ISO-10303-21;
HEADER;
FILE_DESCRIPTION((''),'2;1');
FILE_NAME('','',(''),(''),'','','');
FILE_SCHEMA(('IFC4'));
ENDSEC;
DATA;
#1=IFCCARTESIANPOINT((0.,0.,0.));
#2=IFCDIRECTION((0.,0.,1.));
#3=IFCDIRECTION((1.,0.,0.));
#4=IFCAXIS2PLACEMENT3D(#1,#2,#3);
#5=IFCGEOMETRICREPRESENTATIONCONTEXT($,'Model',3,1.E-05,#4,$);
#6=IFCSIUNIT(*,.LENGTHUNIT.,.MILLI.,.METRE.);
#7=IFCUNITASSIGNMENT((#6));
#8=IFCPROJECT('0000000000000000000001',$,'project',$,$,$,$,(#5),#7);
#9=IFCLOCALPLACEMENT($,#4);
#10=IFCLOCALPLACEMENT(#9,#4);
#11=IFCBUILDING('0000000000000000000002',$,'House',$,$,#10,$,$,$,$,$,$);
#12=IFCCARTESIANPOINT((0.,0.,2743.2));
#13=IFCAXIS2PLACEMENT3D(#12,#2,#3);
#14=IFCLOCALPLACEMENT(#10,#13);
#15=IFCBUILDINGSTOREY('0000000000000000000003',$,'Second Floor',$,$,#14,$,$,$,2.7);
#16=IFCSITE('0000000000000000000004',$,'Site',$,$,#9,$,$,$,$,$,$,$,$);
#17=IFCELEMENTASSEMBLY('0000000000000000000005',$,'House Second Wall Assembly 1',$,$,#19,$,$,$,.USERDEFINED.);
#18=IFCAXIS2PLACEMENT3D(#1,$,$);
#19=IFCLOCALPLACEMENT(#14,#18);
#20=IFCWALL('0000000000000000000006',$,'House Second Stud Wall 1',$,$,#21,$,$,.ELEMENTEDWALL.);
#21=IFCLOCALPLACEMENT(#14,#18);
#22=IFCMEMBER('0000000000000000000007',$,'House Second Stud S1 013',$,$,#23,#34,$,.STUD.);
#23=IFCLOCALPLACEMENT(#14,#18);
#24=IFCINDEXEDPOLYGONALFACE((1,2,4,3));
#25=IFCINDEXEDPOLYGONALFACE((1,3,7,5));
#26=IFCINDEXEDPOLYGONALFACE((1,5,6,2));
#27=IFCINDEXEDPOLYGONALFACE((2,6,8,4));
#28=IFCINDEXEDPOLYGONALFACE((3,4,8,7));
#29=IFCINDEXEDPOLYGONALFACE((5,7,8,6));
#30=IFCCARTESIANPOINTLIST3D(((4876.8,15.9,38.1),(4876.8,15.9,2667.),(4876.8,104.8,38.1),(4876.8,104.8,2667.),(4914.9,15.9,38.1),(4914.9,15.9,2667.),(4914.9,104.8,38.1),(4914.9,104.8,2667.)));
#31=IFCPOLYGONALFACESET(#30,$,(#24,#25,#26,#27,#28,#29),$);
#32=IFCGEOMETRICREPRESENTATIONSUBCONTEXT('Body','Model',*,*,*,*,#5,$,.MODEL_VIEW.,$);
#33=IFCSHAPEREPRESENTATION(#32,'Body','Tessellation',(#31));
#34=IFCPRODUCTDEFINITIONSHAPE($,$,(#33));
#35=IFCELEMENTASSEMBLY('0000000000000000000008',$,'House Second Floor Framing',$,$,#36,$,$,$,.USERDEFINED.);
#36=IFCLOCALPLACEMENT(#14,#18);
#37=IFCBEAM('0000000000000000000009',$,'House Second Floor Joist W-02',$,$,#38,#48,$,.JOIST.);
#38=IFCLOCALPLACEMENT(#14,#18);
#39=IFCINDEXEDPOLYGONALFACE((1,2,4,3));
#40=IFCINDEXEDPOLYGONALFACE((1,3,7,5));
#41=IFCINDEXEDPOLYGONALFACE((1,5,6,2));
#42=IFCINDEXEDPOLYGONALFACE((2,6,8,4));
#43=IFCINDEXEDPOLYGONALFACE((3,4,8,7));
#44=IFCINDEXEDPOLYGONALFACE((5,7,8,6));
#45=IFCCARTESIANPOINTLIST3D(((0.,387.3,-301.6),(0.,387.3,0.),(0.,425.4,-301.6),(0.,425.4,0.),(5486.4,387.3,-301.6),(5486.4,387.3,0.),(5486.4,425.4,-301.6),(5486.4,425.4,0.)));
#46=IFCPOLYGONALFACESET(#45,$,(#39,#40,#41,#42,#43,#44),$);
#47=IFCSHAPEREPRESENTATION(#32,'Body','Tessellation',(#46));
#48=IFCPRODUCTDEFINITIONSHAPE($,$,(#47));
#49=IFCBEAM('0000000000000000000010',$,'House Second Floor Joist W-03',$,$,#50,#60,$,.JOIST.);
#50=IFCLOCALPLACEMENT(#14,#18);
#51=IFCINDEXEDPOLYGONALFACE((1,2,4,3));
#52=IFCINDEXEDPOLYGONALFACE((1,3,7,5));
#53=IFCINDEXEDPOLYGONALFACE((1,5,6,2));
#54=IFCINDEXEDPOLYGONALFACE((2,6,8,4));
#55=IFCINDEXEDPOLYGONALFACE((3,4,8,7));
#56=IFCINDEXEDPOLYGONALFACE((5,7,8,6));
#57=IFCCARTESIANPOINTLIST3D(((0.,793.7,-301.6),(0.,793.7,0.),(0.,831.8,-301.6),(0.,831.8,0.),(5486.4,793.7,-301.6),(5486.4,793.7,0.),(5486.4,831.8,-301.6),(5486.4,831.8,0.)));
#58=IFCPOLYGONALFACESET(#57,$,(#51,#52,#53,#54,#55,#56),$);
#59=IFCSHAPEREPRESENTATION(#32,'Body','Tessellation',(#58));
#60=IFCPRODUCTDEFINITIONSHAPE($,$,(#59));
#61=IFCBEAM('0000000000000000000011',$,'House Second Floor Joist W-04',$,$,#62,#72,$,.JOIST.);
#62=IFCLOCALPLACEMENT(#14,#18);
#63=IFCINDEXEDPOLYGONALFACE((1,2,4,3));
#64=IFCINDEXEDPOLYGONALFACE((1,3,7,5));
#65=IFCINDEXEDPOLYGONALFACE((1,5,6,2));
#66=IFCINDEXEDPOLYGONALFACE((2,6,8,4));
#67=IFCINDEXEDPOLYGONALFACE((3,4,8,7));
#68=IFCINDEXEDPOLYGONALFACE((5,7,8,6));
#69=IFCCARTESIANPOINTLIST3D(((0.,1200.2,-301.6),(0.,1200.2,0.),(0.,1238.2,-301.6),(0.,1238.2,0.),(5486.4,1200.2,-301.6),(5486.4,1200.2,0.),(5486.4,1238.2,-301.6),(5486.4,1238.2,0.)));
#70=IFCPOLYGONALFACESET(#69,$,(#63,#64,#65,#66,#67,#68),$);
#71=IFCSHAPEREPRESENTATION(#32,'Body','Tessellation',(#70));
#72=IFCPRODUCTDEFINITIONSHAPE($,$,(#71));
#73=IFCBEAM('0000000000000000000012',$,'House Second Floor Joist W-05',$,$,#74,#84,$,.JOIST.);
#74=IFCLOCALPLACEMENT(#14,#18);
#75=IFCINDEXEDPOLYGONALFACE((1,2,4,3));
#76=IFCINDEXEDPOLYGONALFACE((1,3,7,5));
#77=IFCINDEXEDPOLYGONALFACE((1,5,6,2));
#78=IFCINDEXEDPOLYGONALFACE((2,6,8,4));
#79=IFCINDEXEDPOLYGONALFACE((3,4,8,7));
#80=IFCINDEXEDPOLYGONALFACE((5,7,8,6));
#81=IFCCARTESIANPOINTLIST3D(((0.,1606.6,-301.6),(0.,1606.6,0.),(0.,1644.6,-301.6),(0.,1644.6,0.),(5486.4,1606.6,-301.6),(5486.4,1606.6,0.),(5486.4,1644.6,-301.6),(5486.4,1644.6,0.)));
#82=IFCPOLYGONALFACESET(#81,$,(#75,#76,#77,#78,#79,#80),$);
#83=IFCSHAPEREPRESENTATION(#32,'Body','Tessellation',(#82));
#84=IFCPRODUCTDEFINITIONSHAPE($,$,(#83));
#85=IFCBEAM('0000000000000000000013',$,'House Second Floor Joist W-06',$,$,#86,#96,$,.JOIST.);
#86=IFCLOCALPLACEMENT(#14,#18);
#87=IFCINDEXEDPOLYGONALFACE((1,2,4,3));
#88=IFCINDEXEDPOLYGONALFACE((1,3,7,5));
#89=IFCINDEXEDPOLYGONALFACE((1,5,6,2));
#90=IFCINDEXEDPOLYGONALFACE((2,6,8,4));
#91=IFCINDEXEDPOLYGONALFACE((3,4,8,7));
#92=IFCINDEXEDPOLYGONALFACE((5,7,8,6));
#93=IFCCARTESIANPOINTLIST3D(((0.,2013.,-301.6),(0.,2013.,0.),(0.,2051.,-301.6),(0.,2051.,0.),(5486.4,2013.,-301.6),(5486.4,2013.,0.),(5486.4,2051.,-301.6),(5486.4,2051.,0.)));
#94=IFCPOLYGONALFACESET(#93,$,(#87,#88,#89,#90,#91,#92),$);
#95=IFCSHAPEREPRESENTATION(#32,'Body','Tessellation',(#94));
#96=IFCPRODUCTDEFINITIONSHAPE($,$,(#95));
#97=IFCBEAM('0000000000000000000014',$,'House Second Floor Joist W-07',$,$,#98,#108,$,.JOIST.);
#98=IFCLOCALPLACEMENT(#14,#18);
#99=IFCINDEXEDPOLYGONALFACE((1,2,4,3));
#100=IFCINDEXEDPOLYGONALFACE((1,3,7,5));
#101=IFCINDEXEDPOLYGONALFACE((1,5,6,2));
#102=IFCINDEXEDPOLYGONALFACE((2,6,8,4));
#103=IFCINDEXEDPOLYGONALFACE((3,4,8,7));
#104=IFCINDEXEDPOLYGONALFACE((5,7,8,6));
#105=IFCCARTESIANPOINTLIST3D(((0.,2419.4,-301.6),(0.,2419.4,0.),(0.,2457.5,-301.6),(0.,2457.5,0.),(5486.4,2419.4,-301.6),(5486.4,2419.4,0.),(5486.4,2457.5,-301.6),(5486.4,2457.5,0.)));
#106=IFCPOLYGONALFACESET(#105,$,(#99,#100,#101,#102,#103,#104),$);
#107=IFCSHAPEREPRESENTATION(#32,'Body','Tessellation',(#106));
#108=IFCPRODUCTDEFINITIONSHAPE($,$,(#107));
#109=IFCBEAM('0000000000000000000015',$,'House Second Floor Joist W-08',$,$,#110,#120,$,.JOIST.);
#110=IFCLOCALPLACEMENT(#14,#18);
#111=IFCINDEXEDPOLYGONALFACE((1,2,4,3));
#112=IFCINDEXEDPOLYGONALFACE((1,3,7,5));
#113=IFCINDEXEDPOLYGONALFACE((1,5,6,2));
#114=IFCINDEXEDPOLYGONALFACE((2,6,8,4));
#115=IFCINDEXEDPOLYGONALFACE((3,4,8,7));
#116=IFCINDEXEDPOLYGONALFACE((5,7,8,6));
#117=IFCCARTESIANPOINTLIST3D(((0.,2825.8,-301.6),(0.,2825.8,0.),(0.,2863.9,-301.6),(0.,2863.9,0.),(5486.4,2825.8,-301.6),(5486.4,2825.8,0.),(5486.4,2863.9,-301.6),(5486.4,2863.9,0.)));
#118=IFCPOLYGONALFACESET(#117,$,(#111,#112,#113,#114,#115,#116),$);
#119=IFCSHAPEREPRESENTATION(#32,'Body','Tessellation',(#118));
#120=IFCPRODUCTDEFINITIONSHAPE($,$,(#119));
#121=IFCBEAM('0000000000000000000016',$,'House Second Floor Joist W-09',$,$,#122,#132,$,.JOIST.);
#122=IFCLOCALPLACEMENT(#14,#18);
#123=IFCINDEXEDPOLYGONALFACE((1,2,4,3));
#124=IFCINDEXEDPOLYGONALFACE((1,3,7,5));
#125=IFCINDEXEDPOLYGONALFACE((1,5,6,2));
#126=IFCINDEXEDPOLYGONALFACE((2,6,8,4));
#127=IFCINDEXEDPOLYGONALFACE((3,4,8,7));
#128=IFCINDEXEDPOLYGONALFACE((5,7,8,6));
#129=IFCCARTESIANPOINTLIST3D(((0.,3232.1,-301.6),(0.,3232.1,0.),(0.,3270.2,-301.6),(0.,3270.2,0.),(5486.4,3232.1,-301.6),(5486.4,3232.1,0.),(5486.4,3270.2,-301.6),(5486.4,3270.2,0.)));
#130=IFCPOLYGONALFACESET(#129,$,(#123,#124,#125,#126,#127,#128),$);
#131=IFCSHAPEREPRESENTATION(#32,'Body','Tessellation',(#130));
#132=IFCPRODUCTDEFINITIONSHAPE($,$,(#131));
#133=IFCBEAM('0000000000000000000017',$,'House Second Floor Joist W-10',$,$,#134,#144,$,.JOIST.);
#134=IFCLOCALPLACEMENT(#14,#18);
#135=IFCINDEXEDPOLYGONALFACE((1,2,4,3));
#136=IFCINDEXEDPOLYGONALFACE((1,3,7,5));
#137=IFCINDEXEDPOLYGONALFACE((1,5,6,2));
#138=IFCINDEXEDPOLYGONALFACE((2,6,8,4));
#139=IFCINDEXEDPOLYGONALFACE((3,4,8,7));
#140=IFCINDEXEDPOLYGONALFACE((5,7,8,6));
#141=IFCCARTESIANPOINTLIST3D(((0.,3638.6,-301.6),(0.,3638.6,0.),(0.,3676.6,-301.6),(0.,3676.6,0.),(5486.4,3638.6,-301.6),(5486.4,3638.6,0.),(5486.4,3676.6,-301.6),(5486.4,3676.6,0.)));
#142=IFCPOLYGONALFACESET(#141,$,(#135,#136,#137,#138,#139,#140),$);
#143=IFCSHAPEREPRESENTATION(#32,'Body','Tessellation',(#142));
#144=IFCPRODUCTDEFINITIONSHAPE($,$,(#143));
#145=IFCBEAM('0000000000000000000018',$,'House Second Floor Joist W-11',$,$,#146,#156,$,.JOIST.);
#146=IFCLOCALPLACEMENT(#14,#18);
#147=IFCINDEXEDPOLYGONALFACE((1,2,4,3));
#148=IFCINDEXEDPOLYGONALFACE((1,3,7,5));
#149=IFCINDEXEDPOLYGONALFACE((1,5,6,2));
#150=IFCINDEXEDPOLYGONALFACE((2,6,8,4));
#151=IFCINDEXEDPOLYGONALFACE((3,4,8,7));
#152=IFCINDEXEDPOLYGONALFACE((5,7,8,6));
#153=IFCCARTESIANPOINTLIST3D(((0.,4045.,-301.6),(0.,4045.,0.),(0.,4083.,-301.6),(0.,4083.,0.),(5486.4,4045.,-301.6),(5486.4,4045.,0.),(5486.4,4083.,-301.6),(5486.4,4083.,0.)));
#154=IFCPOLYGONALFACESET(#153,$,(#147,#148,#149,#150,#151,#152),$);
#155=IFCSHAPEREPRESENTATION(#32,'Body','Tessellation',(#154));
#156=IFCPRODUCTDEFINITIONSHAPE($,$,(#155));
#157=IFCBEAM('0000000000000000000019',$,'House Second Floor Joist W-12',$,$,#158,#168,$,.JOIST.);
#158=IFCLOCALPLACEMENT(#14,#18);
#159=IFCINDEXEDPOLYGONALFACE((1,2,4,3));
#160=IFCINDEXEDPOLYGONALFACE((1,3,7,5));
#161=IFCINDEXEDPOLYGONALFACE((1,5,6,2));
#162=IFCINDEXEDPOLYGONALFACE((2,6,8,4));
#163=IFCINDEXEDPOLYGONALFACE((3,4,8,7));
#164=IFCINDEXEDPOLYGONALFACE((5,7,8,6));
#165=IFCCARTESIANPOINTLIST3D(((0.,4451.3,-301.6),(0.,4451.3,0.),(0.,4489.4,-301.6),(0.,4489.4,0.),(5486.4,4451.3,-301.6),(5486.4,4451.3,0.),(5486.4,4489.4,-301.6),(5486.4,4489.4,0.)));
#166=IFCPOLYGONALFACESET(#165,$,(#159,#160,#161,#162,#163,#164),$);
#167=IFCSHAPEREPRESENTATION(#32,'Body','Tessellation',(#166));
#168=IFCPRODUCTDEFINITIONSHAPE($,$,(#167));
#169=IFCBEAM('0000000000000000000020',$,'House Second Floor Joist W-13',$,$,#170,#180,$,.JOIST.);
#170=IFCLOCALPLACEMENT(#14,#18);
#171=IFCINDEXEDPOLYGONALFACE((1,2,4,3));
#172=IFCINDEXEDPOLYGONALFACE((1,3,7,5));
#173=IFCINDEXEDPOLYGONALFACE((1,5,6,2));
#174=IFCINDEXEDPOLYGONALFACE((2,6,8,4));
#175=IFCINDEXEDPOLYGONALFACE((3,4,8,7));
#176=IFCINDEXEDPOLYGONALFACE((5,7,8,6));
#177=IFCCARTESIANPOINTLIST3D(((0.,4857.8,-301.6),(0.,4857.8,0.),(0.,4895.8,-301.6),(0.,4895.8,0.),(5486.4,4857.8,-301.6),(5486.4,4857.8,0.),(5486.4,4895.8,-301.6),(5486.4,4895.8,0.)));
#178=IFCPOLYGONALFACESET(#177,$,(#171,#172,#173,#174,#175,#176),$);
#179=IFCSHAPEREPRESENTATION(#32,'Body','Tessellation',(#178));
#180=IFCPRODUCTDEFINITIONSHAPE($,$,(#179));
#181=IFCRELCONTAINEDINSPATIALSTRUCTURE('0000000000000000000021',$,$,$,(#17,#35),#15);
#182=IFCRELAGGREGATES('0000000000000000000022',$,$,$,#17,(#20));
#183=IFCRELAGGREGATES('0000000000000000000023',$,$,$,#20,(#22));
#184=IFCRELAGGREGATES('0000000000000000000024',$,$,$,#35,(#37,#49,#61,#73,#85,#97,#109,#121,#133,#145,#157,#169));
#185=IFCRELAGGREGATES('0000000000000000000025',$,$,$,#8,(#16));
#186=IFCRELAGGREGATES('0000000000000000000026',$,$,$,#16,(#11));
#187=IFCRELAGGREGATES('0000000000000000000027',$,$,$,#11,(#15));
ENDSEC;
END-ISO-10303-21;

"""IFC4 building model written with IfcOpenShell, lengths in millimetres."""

from ifc_helpers import new_model, si_unit, frame, origin_with_axes, origin_2d, place, context, subcontext, project, spatial, rectangle, extrude, element, aggregate, save


model = new_model("IFC4")

# Units and contexts
model_context = context("Model", 3, precision=1e-05, world=origin_with_axes())
body_context = subcontext(model_context, "Body", "Model", "MODEL_VIEW")
ifc_project = project(units=[si_unit("LENGTHUNIT", "METRE", prefix="MILLI")], contexts=[model_context])

# Site, building, storey
site_placement = place(None, origin_with_axes())
site = spatial("IfcSite", under=ifc_project, at=site_placement, Name="Site")
building_placement = place(site_placement, origin_with_axes())
building = spatial("IfcBuilding", under=site, at=building_placement, Name="House")
storey_placement = place(building_placement, frame((0.0, 0.0, 2743.2), z_axis=(0.0, 0.0, 1.0), x_axis=(1.0, 0.0, 0.0)))
storey = spatial("IfcBuildingStorey", under=building, at=storey_placement, Name="Second Floor", Elevation=2.7)

# Element assembly, wall, member
assembly_1_placement = place(storey_placement, frame((0.0, 0.0, -2743.2), z_axis=(0.0, 0.0, 1.0), x_axis=(1.0, 0.0, 0.0)))
assembly_1 = element("IfcElementAssembly", 1, at=assembly_1_placement, inside=storey, Name="House Second Wall Assembly 1", PredefinedType="USERDEFINED")
wall_1_placement = place(assembly_1_placement, frame((0.0, 0.0, 2743.2), z_axis=(0.0, 0.0, 1.0), x_axis=(1.0, 0.0, 0.0)))
wall_1 = element("IfcWall", 2, at=wall_1_placement, Name="House Second Stud Wall 1", PredefinedType="ELEMENTEDWALL")
aggregate(assembly_1, [wall_1])
member_1_placement = place(wall_1_placement, frame((4895.9, 60.3, 38.1), z_axis=(0.0, 0.0, 1.0), x_axis=(1.0, 0.0, 0.0)))
member_1 = element("IfcMember", 3, at=member_1_placement, Name="House Second Stud S1 013", PredefinedType="STUD", context=body_context, shape_type="SweptSolid", body=[
    extrude(rectangle(XDim=38.1, YDim=88.9, at=origin_2d()), origin_with_axes(), (0.0, 0.0, 1.0), 2628.9),
])
aggregate(wall_1, [member_1])

# Element assembly, beams
assembly_2_placement = place(storey_placement, frame((0.0, 0.0, -2743.2), z_axis=(0.0, 0.0, 1.0), x_axis=(1.0, 0.0, 0.0)))
assembly_2 = element("IfcElementAssembly", 4, at=assembly_2_placement, inside=storey, Name="House Second Floor Framing", PredefinedType="USERDEFINED")
beam_1_placement = place(assembly_2_placement, frame((0.0, 406.4, 2592.4), z_axis=(1.0, 0.0, 0.0), x_axis=(0.0, 1.0, 0.0)))
beam_1 = element("IfcBeam", 5, at=beam_1_placement, Name="House Second Floor Joist W-02", PredefinedType="JOIST", context=body_context, shape_type="SweptSolid", body=[
    extrude(rectangle(XDim=38.1, YDim=301.6, at=origin_2d()), origin_with_axes(), (0.0, 0.0, 1.0), 5486.4),
])
beam_2_placement = place(assembly_2_placement, frame((0.0, 812.8, 2592.4), z_axis=(1.0, 0.0, 0.0), x_axis=(0.0, 1.0, 0.0)))
beam_2 = element("IfcBeam", 6, at=beam_2_placement, Name="House Second Floor Joist W-03", PredefinedType="JOIST", context=body_context, shape_type="SweptSolid", body=[
    extrude(rectangle(XDim=38.1, YDim=301.6, at=origin_2d()), origin_with_axes(), (0.0, 0.0, 1.0), 5486.4),
])
beam_3_placement = place(assembly_2_placement, frame((0.0, 1219.2, 2592.4), z_axis=(1.0, 0.0, 0.0), x_axis=(0.0, 1.0, 0.0)))
beam_3 = element("IfcBeam", 7, at=beam_3_placement, Name="House Second Floor Joist W-04", PredefinedType="JOIST", context=body_context, shape_type="SweptSolid", body=[
    extrude(rectangle(XDim=38.1, YDim=301.6, at=origin_2d()), origin_with_axes(), (0.0, 0.0, 1.0), 5486.4),
])
beam_4_placement = place(assembly_2_placement, frame((0.0, 1625.6, 2592.4), z_axis=(1.0, 0.0, 0.0), x_axis=(0.0, 1.0, 0.0)))
beam_4 = element("IfcBeam", 8, at=beam_4_placement, Name="House Second Floor Joist W-05", PredefinedType="JOIST", context=body_context, shape_type="SweptSolid", body=[
    extrude(rectangle(XDim=38.1, YDim=301.6, at=origin_2d()), origin_with_axes(), (0.0, 0.0, 1.0), 5486.4),
])
beam_5_placement = place(assembly_2_placement, frame((0.0, 2032.0, 2592.4), z_axis=(1.0, 0.0, 0.0), x_axis=(0.0, 1.0, 0.0)))
beam_5 = element("IfcBeam", 9, at=beam_5_placement, Name="House Second Floor Joist W-06", PredefinedType="JOIST", context=body_context, shape_type="SweptSolid", body=[
    extrude(rectangle(XDim=38.1, YDim=301.6, at=origin_2d()), origin_with_axes(), (0.0, 0.0, 1.0), 5486.4),
])
beam_6_placement = place(assembly_2_placement, frame((0.0, 2438.4, 2592.4), z_axis=(1.0, 0.0, 0.0), x_axis=(0.0, 1.0, 0.0)))
beam_6 = element("IfcBeam", 10, at=beam_6_placement, Name="House Second Floor Joist W-07", PredefinedType="JOIST", context=body_context, shape_type="SweptSolid", body=[
    extrude(rectangle(XDim=38.1, YDim=301.6, at=origin_2d()), origin_with_axes(), (0.0, 0.0, 1.0), 5486.4),
])
beam_7_placement = place(assembly_2_placement, frame((0.0, 2844.8, 2592.4), z_axis=(1.0, 0.0, 0.0), x_axis=(0.0, 1.0, 0.0)))
beam_7 = element("IfcBeam", 11, at=beam_7_placement, Name="House Second Floor Joist W-08", PredefinedType="JOIST", context=body_context, shape_type="SweptSolid", body=[
    extrude(rectangle(XDim=38.1, YDim=301.6, at=origin_2d()), origin_with_axes(), (0.0, 0.0, 1.0), 5486.4),
])
beam_8_placement = place(assembly_2_placement, frame((0.0, 3251.2, 2592.4), z_axis=(1.0, 0.0, 0.0), x_axis=(0.0, 1.0, 0.0)))
beam_8 = element("IfcBeam", 12, at=beam_8_placement, Name="House Second Floor Joist W-09", PredefinedType="JOIST", context=body_context, shape_type="SweptSolid", body=[
    extrude(rectangle(XDim=38.1, YDim=301.6, at=origin_2d()), origin_with_axes(), (0.0, 0.0, 1.0), 5486.4),
])
beam_9_placement = place(assembly_2_placement, frame((0.0, 3657.6, 2592.4), z_axis=(1.0, 0.0, 0.0), x_axis=(0.0, 1.0, 0.0)))
beam_9 = element("IfcBeam", 13, at=beam_9_placement, Name="House Second Floor Joist W-10", PredefinedType="JOIST", context=body_context, shape_type="SweptSolid", body=[
    extrude(rectangle(XDim=38.1, YDim=301.6, at=origin_2d()), origin_with_axes(), (0.0, 0.0, 1.0), 5486.4),
])
beam_10_placement = place(assembly_2_placement, frame((0.0, 4064.0, 2592.4), z_axis=(1.0, 0.0, 0.0), x_axis=(0.0, 1.0, 0.0)))
beam_10 = element("IfcBeam", 14, at=beam_10_placement, Name="House Second Floor Joist W-11", PredefinedType="JOIST", context=body_context, shape_type="SweptSolid", body=[
    extrude(rectangle(XDim=38.1, YDim=301.6, at=origin_2d()), origin_with_axes(), (0.0, 0.0, 1.0), 5486.4),
])
beam_11_placement = place(assembly_2_placement, frame((0.0, 4470.4, 2592.4), z_axis=(1.0, 0.0, 0.0), x_axis=(0.0, 1.0, 0.0)))
beam_11 = element("IfcBeam", 15, at=beam_11_placement, Name="House Second Floor Joist W-12", PredefinedType="JOIST", context=body_context, shape_type="SweptSolid", body=[
    extrude(rectangle(XDim=38.1, YDim=301.6, at=origin_2d()), origin_with_axes(), (0.0, 0.0, 1.0), 5486.4),
])
beam_12_placement = place(assembly_2_placement, frame((0.0, 4876.8, 2592.4), z_axis=(1.0, 0.0, 0.0), x_axis=(0.0, 1.0, 0.0)))
beam_12 = element("IfcBeam", 16, at=beam_12_placement, Name="House Second Floor Joist W-13", PredefinedType="JOIST", context=body_context, shape_type="SweptSolid", body=[
    extrude(rectangle(XDim=38.1, YDim=301.6, at=origin_2d()), origin_with_axes(), (0.0, 0.0, 1.0), 5486.4),
])
aggregate(assembly_2, [beam_1, beam_2, beam_3, beam_4, beam_5, beam_6, beam_7, beam_8, beam_9, beam_10, beam_11, beam_12])

save(model, "model.ifc")
